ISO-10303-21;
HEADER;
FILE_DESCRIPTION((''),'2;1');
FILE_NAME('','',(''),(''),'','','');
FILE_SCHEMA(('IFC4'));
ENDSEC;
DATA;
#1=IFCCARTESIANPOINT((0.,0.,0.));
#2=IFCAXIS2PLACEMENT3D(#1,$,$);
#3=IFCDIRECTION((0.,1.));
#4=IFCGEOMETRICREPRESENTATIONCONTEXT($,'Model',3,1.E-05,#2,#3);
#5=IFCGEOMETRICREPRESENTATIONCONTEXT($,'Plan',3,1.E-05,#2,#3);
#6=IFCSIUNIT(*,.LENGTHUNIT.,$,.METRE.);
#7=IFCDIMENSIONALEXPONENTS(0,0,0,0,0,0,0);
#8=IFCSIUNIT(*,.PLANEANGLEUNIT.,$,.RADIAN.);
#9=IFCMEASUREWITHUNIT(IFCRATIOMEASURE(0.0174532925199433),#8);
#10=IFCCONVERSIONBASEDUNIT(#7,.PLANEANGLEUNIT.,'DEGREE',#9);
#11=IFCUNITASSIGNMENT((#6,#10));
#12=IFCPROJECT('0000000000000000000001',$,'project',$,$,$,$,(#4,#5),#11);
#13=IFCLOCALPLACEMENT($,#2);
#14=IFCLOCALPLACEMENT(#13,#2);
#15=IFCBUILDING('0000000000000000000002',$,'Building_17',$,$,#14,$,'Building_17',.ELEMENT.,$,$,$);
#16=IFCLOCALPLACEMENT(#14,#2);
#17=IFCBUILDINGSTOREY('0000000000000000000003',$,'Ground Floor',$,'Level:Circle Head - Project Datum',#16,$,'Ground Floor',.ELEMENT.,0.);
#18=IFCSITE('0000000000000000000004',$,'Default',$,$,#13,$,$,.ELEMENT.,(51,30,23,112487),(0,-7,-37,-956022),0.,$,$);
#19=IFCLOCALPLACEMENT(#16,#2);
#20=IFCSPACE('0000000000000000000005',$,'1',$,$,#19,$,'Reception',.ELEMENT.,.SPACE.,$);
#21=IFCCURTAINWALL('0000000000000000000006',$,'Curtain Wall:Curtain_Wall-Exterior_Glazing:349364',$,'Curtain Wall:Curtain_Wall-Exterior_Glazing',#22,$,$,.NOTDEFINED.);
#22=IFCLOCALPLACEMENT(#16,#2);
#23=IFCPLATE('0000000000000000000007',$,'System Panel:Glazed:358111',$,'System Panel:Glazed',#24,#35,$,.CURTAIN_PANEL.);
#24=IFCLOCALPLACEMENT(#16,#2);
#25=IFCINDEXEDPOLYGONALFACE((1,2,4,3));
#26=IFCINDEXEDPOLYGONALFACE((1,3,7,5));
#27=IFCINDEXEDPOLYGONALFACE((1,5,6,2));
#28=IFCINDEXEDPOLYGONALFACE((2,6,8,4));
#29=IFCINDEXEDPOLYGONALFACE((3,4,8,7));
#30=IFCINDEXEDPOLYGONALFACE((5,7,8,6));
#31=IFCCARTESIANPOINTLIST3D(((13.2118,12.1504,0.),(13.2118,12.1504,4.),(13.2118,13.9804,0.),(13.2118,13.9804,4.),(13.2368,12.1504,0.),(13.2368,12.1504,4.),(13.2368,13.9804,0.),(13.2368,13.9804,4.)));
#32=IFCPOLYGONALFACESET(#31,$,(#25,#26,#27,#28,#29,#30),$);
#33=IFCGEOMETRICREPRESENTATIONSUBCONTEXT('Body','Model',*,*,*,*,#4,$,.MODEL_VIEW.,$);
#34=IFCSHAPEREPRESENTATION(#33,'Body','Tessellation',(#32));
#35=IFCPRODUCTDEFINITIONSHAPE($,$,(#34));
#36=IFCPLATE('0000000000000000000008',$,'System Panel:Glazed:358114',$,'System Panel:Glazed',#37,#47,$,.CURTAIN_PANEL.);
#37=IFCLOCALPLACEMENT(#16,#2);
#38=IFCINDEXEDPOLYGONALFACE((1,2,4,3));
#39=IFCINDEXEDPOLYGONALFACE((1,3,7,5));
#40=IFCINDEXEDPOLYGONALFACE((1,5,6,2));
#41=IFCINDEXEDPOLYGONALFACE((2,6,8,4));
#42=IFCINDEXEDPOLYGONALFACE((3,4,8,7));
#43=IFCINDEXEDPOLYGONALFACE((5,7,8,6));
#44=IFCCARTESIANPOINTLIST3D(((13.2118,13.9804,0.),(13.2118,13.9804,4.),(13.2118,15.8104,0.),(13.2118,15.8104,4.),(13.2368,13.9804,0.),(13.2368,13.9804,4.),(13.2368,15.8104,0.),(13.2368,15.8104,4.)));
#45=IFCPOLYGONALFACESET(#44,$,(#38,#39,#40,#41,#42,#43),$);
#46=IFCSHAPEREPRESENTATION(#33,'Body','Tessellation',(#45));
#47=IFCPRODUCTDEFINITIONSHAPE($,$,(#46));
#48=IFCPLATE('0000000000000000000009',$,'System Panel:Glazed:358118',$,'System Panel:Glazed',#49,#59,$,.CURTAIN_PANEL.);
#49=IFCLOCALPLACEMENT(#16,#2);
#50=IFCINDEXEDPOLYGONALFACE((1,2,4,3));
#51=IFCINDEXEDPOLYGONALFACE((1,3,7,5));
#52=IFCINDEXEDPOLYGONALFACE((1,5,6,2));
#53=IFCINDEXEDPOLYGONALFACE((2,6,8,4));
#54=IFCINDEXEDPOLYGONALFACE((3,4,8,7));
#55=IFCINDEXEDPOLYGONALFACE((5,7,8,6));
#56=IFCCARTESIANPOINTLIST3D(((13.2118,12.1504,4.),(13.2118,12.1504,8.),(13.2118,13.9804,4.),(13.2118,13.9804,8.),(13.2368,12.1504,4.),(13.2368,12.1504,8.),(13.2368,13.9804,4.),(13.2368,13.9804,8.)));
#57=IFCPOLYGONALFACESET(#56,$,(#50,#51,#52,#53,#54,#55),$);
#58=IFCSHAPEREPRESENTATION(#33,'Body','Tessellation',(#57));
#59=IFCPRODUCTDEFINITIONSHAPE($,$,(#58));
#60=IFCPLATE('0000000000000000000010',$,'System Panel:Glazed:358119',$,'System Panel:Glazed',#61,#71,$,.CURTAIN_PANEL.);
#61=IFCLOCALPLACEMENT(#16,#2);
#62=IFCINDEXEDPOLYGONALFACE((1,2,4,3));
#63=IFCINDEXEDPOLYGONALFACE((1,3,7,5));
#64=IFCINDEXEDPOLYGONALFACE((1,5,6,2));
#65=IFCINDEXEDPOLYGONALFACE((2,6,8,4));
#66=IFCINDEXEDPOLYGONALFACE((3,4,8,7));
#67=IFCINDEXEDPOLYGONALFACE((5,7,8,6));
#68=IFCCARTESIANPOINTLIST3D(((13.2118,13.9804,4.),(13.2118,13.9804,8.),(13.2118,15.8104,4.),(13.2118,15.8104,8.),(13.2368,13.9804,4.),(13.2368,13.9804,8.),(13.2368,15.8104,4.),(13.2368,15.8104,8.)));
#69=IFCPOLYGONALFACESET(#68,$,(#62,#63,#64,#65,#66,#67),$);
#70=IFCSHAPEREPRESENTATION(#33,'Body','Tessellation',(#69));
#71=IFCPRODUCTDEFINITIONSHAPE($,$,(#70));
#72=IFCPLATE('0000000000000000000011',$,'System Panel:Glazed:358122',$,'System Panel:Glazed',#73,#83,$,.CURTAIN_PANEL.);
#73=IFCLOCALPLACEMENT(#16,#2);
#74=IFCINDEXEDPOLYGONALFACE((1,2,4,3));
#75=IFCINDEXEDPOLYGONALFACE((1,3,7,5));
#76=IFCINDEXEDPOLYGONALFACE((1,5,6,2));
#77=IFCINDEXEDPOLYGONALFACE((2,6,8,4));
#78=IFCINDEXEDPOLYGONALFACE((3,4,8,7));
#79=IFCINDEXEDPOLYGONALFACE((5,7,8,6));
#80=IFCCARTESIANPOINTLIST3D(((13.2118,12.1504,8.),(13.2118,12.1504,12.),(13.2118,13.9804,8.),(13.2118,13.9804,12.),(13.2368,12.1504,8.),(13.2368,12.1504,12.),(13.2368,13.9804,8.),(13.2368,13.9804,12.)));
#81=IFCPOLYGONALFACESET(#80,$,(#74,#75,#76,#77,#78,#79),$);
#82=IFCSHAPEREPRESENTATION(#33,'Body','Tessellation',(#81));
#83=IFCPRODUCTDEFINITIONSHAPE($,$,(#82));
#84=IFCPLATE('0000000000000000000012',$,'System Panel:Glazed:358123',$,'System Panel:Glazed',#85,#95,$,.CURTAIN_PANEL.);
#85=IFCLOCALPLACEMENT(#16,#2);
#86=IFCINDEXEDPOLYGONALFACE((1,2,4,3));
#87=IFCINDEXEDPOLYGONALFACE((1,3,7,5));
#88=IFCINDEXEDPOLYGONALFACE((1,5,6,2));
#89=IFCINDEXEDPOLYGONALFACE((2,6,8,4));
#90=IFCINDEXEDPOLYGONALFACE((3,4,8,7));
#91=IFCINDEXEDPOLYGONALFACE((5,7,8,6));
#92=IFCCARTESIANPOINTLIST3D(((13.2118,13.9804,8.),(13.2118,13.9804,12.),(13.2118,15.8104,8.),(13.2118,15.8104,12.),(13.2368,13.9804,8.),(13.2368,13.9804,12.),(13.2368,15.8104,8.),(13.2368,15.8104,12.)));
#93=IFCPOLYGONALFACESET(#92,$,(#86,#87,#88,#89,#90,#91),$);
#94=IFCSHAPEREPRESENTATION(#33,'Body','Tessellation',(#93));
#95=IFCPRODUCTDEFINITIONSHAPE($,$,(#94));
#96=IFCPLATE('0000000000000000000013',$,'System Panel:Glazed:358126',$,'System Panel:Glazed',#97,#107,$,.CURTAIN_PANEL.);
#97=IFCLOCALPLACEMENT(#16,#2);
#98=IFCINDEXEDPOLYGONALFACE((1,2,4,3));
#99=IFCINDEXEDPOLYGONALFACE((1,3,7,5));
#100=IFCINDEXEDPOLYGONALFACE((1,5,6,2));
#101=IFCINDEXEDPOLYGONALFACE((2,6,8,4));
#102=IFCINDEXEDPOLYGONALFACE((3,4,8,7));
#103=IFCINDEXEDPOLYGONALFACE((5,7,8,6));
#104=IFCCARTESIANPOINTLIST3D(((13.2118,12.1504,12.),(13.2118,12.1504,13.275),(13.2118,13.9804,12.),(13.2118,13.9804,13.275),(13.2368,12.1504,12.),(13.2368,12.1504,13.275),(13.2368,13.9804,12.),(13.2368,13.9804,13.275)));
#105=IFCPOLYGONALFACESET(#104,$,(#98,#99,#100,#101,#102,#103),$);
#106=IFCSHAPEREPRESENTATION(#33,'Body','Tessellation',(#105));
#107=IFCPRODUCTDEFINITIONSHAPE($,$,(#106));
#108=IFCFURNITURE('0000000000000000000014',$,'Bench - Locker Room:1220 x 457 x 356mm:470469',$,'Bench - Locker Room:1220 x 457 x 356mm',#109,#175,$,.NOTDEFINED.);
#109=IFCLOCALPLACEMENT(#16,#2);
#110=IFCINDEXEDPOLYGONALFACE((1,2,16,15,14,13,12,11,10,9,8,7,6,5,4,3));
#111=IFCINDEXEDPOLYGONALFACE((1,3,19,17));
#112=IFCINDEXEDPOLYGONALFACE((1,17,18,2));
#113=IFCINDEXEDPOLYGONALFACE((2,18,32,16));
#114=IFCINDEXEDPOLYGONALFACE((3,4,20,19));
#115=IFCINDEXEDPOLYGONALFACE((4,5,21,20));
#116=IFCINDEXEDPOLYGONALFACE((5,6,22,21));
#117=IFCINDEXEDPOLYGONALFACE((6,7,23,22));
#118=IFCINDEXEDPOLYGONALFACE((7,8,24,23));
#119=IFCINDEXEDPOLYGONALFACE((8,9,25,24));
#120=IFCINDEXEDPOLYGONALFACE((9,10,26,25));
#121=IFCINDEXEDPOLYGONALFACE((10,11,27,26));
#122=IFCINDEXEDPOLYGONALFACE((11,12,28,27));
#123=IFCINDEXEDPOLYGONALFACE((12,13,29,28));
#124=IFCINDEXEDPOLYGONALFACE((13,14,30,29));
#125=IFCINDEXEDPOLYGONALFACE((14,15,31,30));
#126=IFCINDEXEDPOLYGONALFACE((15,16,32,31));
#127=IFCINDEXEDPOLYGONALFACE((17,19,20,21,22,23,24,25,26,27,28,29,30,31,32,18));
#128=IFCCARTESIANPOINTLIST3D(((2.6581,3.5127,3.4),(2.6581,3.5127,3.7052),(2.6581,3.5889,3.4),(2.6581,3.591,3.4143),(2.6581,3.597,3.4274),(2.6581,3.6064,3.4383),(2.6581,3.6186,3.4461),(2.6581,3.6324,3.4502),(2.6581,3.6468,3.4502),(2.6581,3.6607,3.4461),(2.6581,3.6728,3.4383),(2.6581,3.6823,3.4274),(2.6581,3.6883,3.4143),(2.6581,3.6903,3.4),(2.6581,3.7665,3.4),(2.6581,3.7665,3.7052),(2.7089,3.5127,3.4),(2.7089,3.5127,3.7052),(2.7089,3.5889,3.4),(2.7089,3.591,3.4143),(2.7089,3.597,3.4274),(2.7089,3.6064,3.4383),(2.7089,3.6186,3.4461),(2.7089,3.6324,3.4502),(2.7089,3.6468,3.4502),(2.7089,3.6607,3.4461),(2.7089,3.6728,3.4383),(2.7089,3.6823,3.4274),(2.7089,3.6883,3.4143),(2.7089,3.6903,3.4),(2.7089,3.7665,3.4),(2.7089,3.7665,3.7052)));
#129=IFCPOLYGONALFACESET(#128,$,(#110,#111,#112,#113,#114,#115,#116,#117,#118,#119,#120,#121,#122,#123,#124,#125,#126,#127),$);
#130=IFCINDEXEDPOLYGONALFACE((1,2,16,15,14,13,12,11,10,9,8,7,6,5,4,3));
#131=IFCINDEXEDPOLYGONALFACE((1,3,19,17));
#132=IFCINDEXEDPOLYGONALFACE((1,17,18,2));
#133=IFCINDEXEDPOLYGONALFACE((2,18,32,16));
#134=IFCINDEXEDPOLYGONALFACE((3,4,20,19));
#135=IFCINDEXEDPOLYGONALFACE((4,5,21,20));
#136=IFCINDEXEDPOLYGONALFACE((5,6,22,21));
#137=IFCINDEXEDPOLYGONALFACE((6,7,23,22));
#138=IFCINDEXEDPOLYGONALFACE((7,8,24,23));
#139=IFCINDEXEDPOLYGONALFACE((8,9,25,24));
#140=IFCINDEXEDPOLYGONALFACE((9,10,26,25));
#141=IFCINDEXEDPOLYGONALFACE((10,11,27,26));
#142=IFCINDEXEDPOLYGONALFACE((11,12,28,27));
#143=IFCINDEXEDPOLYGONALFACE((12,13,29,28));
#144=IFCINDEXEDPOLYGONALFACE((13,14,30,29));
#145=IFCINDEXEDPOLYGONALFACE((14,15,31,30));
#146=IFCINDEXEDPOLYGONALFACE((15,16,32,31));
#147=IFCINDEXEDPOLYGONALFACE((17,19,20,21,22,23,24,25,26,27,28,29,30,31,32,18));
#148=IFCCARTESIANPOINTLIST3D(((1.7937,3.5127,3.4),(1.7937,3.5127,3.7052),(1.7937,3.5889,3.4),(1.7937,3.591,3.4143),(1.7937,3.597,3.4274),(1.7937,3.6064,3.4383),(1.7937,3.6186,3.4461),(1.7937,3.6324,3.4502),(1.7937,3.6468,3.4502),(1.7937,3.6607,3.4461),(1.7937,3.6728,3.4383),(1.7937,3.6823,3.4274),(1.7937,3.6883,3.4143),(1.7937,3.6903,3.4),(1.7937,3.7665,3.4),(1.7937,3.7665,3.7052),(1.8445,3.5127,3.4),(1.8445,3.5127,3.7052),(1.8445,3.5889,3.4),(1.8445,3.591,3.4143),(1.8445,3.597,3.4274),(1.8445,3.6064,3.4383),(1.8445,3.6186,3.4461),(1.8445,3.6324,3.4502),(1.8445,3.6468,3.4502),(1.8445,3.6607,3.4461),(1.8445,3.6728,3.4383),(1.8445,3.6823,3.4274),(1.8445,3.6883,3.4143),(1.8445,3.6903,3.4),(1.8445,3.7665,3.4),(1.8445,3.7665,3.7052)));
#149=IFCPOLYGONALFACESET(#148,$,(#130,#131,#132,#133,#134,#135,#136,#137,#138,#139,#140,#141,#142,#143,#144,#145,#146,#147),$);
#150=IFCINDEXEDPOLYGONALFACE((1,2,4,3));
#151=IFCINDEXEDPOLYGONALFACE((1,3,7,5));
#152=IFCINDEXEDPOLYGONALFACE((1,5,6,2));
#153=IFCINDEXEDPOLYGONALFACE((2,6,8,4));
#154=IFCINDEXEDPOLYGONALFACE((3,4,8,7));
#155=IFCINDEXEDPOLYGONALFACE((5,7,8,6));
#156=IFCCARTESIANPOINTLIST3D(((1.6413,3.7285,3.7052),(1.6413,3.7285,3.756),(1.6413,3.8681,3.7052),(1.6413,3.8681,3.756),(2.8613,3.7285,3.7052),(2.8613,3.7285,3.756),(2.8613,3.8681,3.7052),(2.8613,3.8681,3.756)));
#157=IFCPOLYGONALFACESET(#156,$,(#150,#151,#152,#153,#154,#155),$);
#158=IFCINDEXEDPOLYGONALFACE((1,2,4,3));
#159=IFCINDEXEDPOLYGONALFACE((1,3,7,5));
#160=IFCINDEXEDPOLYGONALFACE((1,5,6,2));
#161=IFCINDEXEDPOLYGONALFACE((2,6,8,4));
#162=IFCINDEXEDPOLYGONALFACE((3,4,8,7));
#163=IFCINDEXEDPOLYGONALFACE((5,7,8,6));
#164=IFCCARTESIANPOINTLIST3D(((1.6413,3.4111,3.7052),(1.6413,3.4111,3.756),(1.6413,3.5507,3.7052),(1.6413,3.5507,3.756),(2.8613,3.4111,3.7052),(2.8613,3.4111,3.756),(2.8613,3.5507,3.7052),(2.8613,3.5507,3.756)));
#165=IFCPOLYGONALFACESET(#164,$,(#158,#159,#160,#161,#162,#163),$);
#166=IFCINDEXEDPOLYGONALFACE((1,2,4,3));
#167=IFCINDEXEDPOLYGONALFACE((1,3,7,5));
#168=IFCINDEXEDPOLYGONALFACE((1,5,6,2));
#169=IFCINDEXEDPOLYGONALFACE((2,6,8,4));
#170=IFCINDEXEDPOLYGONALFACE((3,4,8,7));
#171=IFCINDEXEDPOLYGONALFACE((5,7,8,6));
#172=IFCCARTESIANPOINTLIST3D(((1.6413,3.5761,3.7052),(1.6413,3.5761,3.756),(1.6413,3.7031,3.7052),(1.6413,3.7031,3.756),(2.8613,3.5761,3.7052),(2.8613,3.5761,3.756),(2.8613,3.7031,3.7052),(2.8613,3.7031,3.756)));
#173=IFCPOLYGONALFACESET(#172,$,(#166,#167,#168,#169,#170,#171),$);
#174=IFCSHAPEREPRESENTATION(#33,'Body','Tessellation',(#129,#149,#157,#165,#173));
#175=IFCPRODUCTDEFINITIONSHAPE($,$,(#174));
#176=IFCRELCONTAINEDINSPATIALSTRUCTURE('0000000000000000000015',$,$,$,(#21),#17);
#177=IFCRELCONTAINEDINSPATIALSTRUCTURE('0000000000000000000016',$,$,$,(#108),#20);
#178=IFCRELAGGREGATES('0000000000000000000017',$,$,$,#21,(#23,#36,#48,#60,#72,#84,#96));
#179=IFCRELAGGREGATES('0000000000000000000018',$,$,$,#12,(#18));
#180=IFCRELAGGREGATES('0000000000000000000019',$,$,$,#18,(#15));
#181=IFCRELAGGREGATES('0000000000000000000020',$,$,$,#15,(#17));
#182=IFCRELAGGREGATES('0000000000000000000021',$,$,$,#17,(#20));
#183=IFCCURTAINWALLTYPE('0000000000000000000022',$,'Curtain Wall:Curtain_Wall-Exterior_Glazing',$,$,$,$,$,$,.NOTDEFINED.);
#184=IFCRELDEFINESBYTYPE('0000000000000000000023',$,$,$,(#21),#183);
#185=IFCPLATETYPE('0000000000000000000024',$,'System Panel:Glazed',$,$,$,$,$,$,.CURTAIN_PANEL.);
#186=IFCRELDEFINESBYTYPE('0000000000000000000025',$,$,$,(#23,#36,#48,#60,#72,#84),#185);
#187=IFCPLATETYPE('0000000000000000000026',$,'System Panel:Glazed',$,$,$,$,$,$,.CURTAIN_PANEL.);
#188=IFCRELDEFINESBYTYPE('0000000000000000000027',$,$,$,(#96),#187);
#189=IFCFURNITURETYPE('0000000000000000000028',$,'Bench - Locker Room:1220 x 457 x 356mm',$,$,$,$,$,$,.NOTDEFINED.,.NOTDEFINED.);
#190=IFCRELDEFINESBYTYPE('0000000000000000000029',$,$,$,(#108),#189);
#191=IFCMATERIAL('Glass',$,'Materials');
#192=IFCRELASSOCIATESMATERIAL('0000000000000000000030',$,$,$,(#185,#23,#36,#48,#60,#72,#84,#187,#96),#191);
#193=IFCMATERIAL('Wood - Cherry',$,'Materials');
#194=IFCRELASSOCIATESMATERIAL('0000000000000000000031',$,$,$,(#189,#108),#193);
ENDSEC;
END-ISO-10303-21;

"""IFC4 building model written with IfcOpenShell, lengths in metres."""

from ifc_helpers import new_model, entity, si_unit, converted_unit, direction, frame, origin, place, context, subcontext, project, spatial, line, arc, indexed_curve, outline, extrude, source, transform, mapped, material, type_object, type_shapes, element, aggregate, save


model = new_model("IFC4")

# Units and contexts
model_context = context("Model", 3, precision=1e-05, world=origin(), true_north=direction((0.0, 1.0)))
plan_context = context("Plan", 3, precision=1e-05, world=origin(), true_north=direction((0.0, 1.0)))
body_context = subcontext(model_context, "Body", "Model", "MODEL_VIEW")
ifc_project = project(units=[si_unit("LENGTHUNIT", "METRE"), converted_unit("PLANEANGLEUNIT", "DEGREE", entity("IfcRatioMeasure", 0.0174532925199433), si_unit("PLANEANGLEUNIT", "RADIAN"), dimensions=[0, 0, 0, 0, 0, 0, 0])], contexts=[model_context, plan_context])

# Site, building, storey
site_placement = place(None, origin())
site = spatial("IfcSite", under=ifc_project, at=site_placement, Name="Default", CompositionType="ELEMENT", RefLatitude=(51, 30, 23, 112487), RefLongitude=(0, -7, -37, -956022), RefElevation=0.0)
building_placement = place(site_placement, origin())
building = spatial("IfcBuilding", under=site, at=building_placement, Name="Building_17", LongName="Building_17", CompositionType="ELEMENT")
storey_placement = place(building_placement, origin())
storey = spatial("IfcBuildingStorey", under=building, at=storey_placement, Name="Ground Floor", ObjectType="Level:Circle Head - Project Datum", LongName="Ground Floor", CompositionType="ELEMENT", Elevation=0.0)

# Curtain wall, plates
curtain_wall_type = type_object("IfcCurtainWallType", Name="Curtain Wall:Curtain_Wall-Exterior_Glazing", PredefinedType="NOTDEFINED")
curtain_wall_placement = place(storey_placement, origin())
curtain_wall = element("IfcCurtainWall", 1, at=curtain_wall_placement, inside=storey, type_object=curtain_wall_type, Name="Curtain Wall:Curtain_Wall-Exterior_Glazing:349364", ObjectType="Curtain Wall:Curtain_Wall-Exterior_Glazing", PredefinedType="NOTDEFINED")
ifc_material_1 = material(Name="Glass", Category="Materials")
plate_type_1 = type_object("IfcPlateType", Name="System Panel:Glazed", PredefinedType="CURTAIN_PANEL", material=ifc_material_1)
shared_shape_1 = source(origin(), body_context, "Body", "SweptSolid", [
    extrude(outline(indexed_curve([(-0.0125, -0.915), (0.0125, -0.915), (0.0125, 0.915), (-0.0125, 0.915), (-0.0125, -0.915)], self_intersect=False)), frame((0.0, 0.037, 0.0), z_axis=(0.0, 0.0, 1.0), x_axis=(0.0, 1.0, 0.0)), (0.0, 0.0, 1.0), 4.0),
])
type_shapes(plate_type_1, [shared_shape_1])
plate_1_placement = place(curtain_wall_placement, frame((13.2613, 13.0654, 0.0), z_axis=(0.0, 0.0, 1.0), x_axis=(0.0, 1.0, 0.0)))
plate_1 = element("IfcPlate", 2, at=plate_1_placement, type_object=plate_type_1, material=ifc_material_1, Name="System Panel:Glazed:358111", ObjectType="System Panel:Glazed", PredefinedType="CURTAIN_PANEL", context=body_context, shape_type="MappedRepresentation", body=[
    mapped(shared_shape_1, transform((0.0, 0.0, 0.0), scale=1.0)),
])
plate_2_placement = place(curtain_wall_placement, frame((13.2613, 14.8954, 0.0), z_axis=(0.0, 0.0, 1.0), x_axis=(0.0, 1.0, 0.0)))
plate_2 = element("IfcPlate", 3, at=plate_2_placement, type_object=plate_type_1, material=ifc_material_1, Name="System Panel:Glazed:358114", ObjectType="System Panel:Glazed", PredefinedType="CURTAIN_PANEL", context=body_context, shape_type="MappedRepresentation", body=[
    mapped(shared_shape_1, transform((0.0, 0.0, 0.0), scale=1.0)),
])
plate_3_placement = place(curtain_wall_placement, frame((13.2613, 13.0654, 4.0), z_axis=(0.0, 0.0, 1.0), x_axis=(0.0, 1.0, 0.0)))
plate_3 = element("IfcPlate", 4, at=plate_3_placement, type_object=plate_type_1, material=ifc_material_1, Name="System Panel:Glazed:358118", ObjectType="System Panel:Glazed", PredefinedType="CURTAIN_PANEL", context=body_context, shape_type="MappedRepresentation", body=[
    mapped(shared_shape_1, transform((0.0, 0.0, 0.0), scale=1.0)),
])
plate_4_placement = place(curtain_wall_placement, frame((13.2613, 14.8954, 4.0), z_axis=(0.0, 0.0, 1.0), x_axis=(0.0, 1.0, 0.0)))
plate_4 = element("IfcPlate", 5, at=plate_4_placement, type_object=plate_type_1, material=ifc_material_1, Name="System Panel:Glazed:358119", ObjectType="System Panel:Glazed", PredefinedType="CURTAIN_PANEL", context=body_context, shape_type="MappedRepresentation", body=[
    mapped(shared_shape_1, transform((0.0, 0.0, 0.0), scale=1.0)),
])
plate_5_placement = place(curtain_wall_placement, frame((13.2613, 13.0654, 8.0), z_axis=(0.0, 0.0, 1.0), x_axis=(0.0, 1.0, 0.0)))
plate_5 = element("IfcPlate", 6, at=plate_5_placement, type_object=plate_type_1, material=ifc_material_1, Name="System Panel:Glazed:358122", ObjectType="System Panel:Glazed", PredefinedType="CURTAIN_PANEL", context=body_context, shape_type="MappedRepresentation", body=[
    mapped(shared_shape_1, transform((0.0, 0.0, 0.0), scale=1.0)),
])
plate_6_placement = place(curtain_wall_placement, frame((13.2613, 14.8954, 8.0), z_axis=(0.0, 0.0, 1.0), x_axis=(0.0, 1.0, 0.0)))
plate_6 = element("IfcPlate", 7, at=plate_6_placement, type_object=plate_type_1, material=ifc_material_1, Name="System Panel:Glazed:358123", ObjectType="System Panel:Glazed", PredefinedType="CURTAIN_PANEL", context=body_context, shape_type="MappedRepresentation", body=[
    mapped(shared_shape_1, transform((0.0, 0.0, 0.0), scale=1.0)),
])
plate_type_2 = type_object("IfcPlateType", Name="System Panel:Glazed", PredefinedType="CURTAIN_PANEL", material=ifc_material_1)
shared_shape_2 = source(origin(), body_context, "Body", "SweptSolid", [
    extrude(outline(indexed_curve([(-0.0125, -0.915), (0.0125, -0.915), (0.0125, 0.915), (-0.0125, 0.915), (-0.0125, -0.915)], self_intersect=False)), frame((0.0, 0.037, 0.0), z_axis=(0.0, 0.0, 1.0), x_axis=(0.0, 1.0, 0.0)), (0.0, 0.0, 1.0), 1.275),
])
type_shapes(plate_type_2, [shared_shape_2])
plate_7_placement = place(curtain_wall_placement, frame((13.2613, 13.0654, 12.0), z_axis=(0.0, 0.0, 1.0), x_axis=(0.0, 1.0, 0.0)))
plate_7 = element("IfcPlate", 8, at=plate_7_placement, type_object=plate_type_2, material=ifc_material_1, Name="System Panel:Glazed:358126", ObjectType="System Panel:Glazed", PredefinedType="CURTAIN_PANEL", context=body_context, shape_type="MappedRepresentation", body=[
    mapped(shared_shape_2, transform((0.0, 0.0, 0.0), scale=1.0)),
])
aggregate(curtain_wall, [plate_1, plate_2, plate_3, plate_4, plate_5, plate_6, plate_7])

# Shared definitions
space_placement = place(storey_placement, origin())
space = spatial("IfcSpace", under=storey, at=space_placement, Name="1", LongName="Reception", CompositionType="ELEMENT", PredefinedType="SPACE")

# Furniture
ifc_material_2 = material(Name="Wood - Cherry", Category="Materials")
furniture_type = type_object("IfcFurnitureType", Name="Bench - Locker Room:1220 x 457 x 356mm", AssemblyPlace="NOTDEFINED", PredefinedType="NOTDEFINED", material=ifc_material_2)
shared_shape_3 = source(origin(), body_context, "Body", "SweptSolid", [
    extrude(outline(indexed_curve([(-0.1269, 0.1017), (-0.1269, -0.2035), (0.1269, -0.2035), (0.1269, 0.1017), (0.0507, 0.1017), (0.0, 0.051), (-0.0507, 0.1017)], segments=[line(1, 2, 3, 4, 5), arc(5, 6, 7), line(7, 1)], self_intersect=False)), frame((0.2515, -0.1807, 0.1017), z_axis=(-1.0, 0.0, 0.0), x_axis=(0.0, 1.0, 0.0)), (0.0, 0.0, -1.0), 0.0508),
    extrude(outline(indexed_curve([(-0.1017, -0.1269), (0.2035, -0.1269), (0.2035, 0.1269), (-0.1017, 0.1269), (-0.1017, 0.0507), (-0.051, 0.0), (-0.1017, -0.0507)], segments=[line(1, 2, 3, 4, 5), arc(5, 6, 7), line(7, 1)], self_intersect=False)), frame((-0.6129, -0.1807, 0.1017), z_axis=(1.0, 0.0, 0.0), x_axis=(0.0, 0.0, 1.0)), (0.0, 0.0, 1.0), 0.0508),
    extrude(outline(indexed_curve([(-0.61, -0.0698), (0.61, -0.0698), (0.61, 0.0698), (-0.61, 0.0698), (-0.61, -0.0698)], self_intersect=False)), frame((-0.1553, -0.022, 0.3052), z_axis=(0.0, 0.0, 1.0), x_axis=(-1.0, 0.0, 0.0)), (0.0, 0.0, 1.0), 0.0508),
    extrude(outline(indexed_curve([(-0.0698, -0.61), (0.0698, -0.61), (0.0698, 0.61), (-0.0698, 0.61), (-0.0698, -0.61)], self_intersect=False)), frame((-0.1553, -0.3394, 0.3052), z_axis=(0.0, 0.0, 1.0), x_axis=(0.0, 1.0, 0.0)), (0.0, 0.0, 1.0), 0.0508),
    extrude(outline(indexed_curve([(-0.61, -0.0635), (0.61, -0.0635), (0.61, 0.0635), (-0.61, 0.0635), (-0.61, -0.0635)], self_intersect=False)), frame((-0.1553, -0.1807, 0.3052), z_axis=(0.0, 0.0, 1.0), x_axis=(-1.0, 0.0, 0.0)), (0.0, 0.0, 1.0), 0.0508),
])
type_shapes(furniture_type, [shared_shape_3])
furniture_placement = place(space_placement, frame((2.4066, 3.8203, 3.4)))
element("IfcFurniture", 9, at=furniture_placement, inside=space, type_object=furniture_type, material=ifc_material_2, Name="Bench - Locker Room:1220 x 457 x 356mm:470469", ObjectType="Bench - Locker Room:1220 x 457 x 356mm", PredefinedType="NOTDEFINED", context=body_context, shape_type="MappedRepresentation", body=[
    mapped(shared_shape_3, transform((0.0, 0.0, 0.0), scale=1.0)),
])

save(model, "model.ifc")
